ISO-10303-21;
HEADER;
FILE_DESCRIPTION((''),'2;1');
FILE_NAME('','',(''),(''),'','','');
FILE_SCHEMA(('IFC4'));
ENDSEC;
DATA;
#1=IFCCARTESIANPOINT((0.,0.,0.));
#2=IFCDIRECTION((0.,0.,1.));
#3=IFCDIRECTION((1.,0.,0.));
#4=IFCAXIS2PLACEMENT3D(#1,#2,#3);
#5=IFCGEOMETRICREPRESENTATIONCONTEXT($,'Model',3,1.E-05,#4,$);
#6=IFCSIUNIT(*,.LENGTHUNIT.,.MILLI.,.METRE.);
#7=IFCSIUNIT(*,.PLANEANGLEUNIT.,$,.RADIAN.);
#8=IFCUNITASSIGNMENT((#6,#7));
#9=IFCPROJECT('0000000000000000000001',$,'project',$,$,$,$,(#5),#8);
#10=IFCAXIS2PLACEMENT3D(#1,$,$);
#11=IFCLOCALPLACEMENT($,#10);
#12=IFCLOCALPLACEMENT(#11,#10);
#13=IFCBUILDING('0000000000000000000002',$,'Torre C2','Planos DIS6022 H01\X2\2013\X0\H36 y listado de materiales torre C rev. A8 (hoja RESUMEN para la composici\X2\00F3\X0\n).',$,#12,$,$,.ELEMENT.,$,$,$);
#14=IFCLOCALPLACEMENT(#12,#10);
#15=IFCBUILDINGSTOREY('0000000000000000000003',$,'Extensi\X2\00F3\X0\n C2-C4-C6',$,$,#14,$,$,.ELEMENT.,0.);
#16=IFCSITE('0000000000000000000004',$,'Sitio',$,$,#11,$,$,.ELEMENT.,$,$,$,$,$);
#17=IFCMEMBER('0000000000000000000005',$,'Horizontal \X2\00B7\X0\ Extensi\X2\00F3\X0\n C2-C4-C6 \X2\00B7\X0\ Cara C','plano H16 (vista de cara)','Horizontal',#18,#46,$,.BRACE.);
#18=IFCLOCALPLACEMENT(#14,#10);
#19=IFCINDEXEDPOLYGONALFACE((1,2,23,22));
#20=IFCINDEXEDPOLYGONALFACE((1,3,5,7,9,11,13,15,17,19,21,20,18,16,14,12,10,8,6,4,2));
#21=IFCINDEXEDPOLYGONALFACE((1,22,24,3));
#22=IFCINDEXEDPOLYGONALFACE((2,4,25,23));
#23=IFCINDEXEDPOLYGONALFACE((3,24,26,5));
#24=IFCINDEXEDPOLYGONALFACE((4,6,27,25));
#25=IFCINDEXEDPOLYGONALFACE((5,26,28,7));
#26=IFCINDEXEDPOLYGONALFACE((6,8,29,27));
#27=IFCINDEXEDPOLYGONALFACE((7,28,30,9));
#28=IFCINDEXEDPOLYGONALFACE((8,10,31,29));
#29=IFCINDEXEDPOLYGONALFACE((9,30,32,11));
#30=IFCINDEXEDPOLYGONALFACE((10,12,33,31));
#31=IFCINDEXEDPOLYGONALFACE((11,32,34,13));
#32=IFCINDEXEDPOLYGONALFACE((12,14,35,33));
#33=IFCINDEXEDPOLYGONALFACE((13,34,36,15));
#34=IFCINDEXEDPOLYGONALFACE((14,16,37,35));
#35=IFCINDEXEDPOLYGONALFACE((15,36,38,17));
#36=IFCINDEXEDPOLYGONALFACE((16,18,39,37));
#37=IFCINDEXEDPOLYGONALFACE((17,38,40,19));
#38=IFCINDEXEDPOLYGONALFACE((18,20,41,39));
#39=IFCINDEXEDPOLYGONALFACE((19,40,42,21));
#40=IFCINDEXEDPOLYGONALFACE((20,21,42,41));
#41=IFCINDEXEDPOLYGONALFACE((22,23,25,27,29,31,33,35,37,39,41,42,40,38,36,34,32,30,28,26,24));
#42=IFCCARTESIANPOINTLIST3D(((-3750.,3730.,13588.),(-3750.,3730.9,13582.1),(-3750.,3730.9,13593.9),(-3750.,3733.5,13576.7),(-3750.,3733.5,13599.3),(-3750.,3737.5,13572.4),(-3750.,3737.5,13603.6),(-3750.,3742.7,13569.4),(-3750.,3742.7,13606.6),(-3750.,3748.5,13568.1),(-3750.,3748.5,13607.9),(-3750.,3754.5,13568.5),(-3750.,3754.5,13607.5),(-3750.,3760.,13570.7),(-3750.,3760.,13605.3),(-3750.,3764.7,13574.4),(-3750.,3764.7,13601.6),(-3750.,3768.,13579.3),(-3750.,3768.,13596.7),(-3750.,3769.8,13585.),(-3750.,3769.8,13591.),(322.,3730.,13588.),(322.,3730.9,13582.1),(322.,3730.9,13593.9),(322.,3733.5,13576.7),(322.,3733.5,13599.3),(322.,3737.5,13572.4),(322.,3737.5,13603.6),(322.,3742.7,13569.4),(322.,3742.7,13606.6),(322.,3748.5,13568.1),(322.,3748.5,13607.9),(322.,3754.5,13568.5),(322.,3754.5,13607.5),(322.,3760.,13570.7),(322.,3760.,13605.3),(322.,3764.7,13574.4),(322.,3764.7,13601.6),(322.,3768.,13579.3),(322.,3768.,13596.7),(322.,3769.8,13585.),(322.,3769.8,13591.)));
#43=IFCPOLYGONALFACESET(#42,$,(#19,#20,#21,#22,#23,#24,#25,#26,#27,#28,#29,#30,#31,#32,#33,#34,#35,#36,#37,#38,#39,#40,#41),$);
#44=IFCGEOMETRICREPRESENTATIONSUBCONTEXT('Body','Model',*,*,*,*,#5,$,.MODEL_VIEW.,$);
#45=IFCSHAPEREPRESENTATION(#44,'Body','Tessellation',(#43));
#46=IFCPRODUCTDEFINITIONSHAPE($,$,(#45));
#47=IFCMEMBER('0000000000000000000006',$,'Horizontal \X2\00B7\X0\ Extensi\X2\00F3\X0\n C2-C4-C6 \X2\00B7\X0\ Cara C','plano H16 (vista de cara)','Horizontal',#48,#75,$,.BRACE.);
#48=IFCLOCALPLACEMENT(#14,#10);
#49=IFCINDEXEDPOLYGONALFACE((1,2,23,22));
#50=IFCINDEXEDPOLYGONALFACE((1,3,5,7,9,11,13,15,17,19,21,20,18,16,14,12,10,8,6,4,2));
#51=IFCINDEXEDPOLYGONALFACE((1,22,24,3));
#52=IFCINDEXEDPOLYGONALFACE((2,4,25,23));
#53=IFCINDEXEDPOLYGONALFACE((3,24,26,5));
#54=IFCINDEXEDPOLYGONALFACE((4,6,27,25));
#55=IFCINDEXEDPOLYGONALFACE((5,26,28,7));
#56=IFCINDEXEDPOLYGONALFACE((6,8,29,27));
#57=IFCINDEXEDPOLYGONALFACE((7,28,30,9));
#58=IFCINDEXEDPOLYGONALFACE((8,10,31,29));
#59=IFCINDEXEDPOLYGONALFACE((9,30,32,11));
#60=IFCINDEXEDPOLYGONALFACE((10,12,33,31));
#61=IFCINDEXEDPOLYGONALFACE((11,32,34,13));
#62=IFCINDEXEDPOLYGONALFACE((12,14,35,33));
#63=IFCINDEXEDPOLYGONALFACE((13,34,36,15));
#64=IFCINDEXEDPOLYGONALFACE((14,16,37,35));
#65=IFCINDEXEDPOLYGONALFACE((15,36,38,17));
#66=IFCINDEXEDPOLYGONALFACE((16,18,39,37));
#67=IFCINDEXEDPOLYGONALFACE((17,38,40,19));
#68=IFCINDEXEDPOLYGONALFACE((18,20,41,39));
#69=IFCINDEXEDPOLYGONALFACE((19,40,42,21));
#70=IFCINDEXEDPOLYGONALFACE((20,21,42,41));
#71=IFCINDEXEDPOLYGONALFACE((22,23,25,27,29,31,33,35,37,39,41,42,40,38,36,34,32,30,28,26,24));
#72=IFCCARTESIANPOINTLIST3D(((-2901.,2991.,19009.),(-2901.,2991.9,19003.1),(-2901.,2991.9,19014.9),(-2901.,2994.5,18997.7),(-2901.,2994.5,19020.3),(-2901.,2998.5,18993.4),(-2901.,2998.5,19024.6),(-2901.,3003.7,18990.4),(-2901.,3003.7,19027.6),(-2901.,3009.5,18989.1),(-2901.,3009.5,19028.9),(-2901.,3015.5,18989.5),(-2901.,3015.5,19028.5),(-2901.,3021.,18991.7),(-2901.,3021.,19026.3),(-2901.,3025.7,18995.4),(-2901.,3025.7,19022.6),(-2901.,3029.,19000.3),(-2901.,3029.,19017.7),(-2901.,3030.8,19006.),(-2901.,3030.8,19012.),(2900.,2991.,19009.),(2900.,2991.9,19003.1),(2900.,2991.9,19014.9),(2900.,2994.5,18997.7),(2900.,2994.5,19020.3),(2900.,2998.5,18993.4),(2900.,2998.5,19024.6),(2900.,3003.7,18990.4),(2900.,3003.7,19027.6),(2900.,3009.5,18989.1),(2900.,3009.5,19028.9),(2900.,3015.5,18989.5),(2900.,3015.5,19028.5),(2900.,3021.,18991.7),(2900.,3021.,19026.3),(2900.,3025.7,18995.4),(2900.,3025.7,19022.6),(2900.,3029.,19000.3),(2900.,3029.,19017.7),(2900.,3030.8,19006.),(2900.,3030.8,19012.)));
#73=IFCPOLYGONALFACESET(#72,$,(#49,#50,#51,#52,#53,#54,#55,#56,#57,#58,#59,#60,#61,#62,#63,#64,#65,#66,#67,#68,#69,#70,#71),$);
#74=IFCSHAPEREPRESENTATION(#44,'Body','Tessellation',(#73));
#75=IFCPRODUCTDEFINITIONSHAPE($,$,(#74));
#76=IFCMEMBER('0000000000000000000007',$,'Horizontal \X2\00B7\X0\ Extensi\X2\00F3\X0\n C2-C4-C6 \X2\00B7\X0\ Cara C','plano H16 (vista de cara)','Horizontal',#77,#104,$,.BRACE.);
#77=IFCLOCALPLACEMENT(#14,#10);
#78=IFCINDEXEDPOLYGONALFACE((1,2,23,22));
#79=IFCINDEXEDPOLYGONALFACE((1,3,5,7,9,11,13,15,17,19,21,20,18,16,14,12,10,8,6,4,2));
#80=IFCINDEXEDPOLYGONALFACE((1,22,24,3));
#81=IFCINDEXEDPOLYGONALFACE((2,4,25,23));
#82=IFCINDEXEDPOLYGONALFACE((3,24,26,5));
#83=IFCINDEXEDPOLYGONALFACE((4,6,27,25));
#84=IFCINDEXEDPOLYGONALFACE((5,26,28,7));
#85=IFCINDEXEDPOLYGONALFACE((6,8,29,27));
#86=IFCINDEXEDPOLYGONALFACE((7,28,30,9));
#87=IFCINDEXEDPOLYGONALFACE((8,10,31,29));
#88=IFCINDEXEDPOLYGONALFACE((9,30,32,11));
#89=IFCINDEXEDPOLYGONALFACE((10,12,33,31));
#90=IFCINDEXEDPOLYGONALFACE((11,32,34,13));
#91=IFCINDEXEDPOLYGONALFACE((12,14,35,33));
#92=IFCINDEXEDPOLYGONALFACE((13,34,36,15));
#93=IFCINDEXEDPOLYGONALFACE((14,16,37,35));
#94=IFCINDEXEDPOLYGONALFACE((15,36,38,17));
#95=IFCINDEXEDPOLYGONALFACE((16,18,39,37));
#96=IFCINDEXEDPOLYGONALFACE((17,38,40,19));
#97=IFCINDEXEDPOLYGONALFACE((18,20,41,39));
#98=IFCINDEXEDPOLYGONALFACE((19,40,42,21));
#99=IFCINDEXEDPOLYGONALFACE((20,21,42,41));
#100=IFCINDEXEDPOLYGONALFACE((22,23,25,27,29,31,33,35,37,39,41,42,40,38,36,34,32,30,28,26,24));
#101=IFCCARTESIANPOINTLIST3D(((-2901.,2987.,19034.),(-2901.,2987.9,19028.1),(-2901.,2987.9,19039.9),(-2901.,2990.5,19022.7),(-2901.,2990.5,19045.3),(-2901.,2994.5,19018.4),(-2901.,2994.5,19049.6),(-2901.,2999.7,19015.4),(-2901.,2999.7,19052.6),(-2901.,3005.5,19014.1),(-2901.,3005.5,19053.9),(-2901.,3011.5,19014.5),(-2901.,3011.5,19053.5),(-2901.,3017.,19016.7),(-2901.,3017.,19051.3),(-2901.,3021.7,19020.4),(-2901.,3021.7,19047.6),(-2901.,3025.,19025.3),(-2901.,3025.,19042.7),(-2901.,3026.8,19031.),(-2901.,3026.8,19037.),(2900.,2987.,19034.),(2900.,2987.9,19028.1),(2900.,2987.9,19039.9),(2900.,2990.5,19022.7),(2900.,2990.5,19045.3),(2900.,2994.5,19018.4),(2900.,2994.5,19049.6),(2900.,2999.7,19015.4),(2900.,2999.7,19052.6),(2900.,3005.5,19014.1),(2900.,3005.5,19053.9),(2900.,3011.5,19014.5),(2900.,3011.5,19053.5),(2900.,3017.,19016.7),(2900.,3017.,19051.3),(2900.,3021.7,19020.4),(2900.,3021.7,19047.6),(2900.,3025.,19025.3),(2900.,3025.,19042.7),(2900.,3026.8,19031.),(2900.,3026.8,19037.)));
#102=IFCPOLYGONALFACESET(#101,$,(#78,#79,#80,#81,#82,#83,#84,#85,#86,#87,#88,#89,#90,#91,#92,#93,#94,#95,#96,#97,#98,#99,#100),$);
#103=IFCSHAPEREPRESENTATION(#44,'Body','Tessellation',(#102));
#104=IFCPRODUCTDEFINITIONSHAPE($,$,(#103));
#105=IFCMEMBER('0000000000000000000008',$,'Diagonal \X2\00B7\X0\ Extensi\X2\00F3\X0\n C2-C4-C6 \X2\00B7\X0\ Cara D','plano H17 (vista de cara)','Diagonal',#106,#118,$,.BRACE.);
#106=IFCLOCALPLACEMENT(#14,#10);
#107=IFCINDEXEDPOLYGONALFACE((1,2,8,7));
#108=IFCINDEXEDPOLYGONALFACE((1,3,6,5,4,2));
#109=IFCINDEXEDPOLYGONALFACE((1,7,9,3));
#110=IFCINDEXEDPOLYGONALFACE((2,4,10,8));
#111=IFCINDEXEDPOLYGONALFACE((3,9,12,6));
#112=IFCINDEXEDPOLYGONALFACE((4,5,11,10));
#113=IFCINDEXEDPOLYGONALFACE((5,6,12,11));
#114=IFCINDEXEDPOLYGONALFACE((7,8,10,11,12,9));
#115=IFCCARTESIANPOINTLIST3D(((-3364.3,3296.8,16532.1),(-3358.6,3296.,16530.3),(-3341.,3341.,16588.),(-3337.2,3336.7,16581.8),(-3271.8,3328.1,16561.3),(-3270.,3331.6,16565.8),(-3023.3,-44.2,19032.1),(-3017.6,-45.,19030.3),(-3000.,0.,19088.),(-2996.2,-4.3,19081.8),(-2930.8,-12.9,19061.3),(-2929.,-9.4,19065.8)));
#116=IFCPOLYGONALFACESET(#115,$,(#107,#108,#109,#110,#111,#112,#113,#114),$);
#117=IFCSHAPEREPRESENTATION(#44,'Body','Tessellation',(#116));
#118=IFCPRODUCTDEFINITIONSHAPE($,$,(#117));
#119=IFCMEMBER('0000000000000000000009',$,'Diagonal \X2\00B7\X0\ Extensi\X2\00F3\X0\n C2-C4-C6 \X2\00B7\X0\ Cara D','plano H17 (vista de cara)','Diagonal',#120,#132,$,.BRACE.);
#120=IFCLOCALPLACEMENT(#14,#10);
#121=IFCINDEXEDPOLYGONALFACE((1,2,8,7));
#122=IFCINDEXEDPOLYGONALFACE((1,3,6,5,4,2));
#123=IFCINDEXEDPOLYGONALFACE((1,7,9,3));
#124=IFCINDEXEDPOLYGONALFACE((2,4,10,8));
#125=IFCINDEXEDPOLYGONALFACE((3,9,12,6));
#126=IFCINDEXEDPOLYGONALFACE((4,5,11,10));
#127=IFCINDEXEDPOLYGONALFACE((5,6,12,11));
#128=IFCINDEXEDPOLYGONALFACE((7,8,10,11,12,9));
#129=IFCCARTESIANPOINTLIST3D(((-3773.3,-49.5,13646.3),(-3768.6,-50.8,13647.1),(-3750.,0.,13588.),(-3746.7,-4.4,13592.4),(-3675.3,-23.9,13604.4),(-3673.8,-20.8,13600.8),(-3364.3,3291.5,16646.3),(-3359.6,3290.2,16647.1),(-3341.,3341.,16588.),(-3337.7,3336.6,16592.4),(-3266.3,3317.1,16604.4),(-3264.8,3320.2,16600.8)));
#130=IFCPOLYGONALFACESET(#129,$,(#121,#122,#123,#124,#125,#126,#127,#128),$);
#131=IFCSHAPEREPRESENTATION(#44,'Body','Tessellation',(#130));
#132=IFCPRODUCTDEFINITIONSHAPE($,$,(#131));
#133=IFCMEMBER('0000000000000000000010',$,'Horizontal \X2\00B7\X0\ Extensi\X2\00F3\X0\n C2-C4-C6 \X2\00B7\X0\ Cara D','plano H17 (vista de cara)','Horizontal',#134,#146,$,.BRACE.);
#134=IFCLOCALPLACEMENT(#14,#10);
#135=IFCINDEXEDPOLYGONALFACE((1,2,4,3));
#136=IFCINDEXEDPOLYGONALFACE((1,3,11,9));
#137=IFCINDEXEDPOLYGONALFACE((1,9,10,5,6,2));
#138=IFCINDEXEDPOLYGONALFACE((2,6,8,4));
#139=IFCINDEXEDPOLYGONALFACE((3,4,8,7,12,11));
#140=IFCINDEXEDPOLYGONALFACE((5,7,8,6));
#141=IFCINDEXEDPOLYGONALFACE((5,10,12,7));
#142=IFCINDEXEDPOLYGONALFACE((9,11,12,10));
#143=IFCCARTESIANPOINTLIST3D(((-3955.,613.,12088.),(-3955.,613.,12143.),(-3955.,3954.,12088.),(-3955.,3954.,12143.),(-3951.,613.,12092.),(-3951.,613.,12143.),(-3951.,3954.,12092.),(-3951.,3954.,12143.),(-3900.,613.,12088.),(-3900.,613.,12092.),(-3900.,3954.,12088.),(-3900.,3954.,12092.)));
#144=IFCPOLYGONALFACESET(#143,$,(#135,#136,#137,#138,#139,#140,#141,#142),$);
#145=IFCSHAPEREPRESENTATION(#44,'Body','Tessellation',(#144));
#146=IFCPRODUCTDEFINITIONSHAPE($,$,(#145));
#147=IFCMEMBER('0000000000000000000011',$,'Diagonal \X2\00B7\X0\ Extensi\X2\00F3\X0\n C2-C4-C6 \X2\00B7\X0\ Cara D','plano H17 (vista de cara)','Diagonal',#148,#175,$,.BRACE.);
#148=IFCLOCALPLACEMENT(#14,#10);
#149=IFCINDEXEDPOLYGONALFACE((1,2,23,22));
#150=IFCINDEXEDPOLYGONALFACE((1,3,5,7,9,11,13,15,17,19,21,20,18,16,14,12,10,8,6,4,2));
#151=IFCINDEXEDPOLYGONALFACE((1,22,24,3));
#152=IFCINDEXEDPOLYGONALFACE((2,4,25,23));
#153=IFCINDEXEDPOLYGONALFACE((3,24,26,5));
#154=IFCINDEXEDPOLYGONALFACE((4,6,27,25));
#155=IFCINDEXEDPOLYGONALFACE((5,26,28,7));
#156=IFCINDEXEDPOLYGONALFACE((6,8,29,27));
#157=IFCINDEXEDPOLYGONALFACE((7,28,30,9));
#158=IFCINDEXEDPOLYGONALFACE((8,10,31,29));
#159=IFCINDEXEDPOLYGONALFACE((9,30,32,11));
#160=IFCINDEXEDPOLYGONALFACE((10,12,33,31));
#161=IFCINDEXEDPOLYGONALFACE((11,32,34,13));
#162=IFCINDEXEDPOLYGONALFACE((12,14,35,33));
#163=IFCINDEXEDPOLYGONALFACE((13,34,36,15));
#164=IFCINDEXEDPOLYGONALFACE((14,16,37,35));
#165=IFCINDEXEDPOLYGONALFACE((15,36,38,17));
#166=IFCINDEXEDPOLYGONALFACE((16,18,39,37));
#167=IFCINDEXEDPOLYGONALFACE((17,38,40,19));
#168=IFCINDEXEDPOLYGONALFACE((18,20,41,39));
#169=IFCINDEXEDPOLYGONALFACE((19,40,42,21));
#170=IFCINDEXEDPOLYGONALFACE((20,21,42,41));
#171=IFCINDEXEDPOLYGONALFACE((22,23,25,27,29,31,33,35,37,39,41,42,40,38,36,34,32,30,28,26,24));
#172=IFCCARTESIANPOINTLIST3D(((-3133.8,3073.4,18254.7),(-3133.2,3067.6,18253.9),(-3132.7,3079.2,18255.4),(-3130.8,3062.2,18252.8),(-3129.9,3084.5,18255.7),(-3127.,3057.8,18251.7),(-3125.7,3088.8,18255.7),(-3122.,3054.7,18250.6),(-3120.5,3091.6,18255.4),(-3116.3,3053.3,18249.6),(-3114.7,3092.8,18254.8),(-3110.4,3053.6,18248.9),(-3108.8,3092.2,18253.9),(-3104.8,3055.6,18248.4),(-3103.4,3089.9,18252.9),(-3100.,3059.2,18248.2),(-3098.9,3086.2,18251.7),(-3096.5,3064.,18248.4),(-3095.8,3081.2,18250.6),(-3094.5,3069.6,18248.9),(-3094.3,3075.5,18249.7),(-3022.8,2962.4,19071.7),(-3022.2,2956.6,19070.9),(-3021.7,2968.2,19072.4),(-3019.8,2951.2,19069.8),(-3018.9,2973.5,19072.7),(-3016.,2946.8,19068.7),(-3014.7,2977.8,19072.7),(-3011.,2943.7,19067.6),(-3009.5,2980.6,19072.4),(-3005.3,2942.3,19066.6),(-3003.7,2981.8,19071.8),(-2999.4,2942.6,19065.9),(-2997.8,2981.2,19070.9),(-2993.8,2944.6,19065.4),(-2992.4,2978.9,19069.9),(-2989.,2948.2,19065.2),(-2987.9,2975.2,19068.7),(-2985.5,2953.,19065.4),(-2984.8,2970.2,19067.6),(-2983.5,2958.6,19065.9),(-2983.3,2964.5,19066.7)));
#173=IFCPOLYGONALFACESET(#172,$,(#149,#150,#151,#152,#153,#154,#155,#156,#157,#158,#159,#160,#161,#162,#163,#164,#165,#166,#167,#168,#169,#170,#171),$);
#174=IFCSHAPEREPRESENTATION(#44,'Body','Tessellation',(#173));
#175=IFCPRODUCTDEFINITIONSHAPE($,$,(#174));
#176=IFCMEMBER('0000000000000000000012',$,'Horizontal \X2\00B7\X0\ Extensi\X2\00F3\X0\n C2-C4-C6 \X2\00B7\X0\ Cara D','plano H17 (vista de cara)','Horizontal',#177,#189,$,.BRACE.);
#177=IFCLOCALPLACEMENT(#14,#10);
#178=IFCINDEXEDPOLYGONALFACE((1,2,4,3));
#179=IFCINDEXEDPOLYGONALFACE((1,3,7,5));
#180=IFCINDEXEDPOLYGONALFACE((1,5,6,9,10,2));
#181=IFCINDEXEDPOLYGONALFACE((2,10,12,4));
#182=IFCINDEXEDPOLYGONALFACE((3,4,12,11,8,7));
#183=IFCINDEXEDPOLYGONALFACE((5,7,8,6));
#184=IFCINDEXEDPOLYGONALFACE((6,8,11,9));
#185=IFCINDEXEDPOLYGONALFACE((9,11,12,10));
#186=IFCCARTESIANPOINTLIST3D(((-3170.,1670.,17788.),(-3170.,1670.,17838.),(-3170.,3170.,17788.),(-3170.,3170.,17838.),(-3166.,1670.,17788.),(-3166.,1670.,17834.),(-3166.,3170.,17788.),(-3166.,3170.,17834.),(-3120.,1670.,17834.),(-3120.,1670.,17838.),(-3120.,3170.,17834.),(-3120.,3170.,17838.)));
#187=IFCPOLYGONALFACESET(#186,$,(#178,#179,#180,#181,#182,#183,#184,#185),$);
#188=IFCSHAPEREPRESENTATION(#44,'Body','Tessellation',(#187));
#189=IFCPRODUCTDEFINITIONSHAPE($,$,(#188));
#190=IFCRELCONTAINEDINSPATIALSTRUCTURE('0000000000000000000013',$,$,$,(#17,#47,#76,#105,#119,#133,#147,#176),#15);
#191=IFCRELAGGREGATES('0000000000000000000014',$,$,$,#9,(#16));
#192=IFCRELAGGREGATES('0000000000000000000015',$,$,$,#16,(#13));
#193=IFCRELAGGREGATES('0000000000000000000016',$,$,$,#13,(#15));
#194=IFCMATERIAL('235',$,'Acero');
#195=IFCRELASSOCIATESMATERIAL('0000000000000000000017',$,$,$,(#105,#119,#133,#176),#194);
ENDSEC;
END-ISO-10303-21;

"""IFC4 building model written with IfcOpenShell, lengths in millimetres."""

from ifc_helpers import new_model, si_unit, frame, frame_2d, origin, origin_with_axes, place, context, subcontext, project, spatial, circle, l_section, extrude, material, element, save


model = new_model("IFC4")

# Units and contexts
model_context = context("Model", 3, precision=1e-05, world=origin_with_axes())
body_context = subcontext(model_context, "Body", "Model", "MODEL_VIEW")
ifc_project = project(units=[si_unit("LENGTHUNIT", "METRE", prefix="MILLI"), si_unit("PLANEANGLEUNIT", "RADIAN")], contexts=[model_context])

# Site, building, storey
site_placement = place(None, origin())
site = spatial("IfcSite", under=ifc_project, at=site_placement, Name="Sitio", CompositionType="ELEMENT")
building_placement = place(site_placement, origin())
building = spatial("IfcBuilding", under=site, at=building_placement, Name="Torre C2", Description="Planos DIS6022 H01–H36 y listado de materiales torre C rev. A8 (hoja RESUMEN para la composición).", CompositionType="ELEMENT")
storey_placement = place(building_placement, origin())
storey = spatial("IfcBuildingStorey", under=building, at=storey_placement, Name="Extensión C2-C4-C6", CompositionType="ELEMENT", Elevation=0.0)

# Members
ifc_material_1 = material(Name="235", Category="Acero")
member_1_placement = place(storey_placement, frame((-3750.0, 3750.0, 13588.0), z_axis=(1.0, 0.0, 0.0), x_axis=(0.0, -1.0, 0.0)))
element("IfcMember", 1, at=member_1_placement, inside=storey, Name="Horizontal · Extensión C2-C4-C6 · Cara C", Description="plano H16 (vista de cara)", ObjectType="Horizontal", PredefinedType="BRACE", context=body_context, shape_type="SweptSolid", body=[
    extrude(circle(Radius=20.0), None, (0.0, 0.0, 1.0), 4072.0),
])
for number, where, z_axis, x_axis, name in (
    (2, (-2901.0, 3011.0, 19009.0), (1.0, 0.0, 0.0), (0.0, -1.0, 0.0), "Horizontal · Extensión C2-C4-C6 · Cara C"),
    (3, (-2901.0, 3007.0, 19034.0), (1.0, 0.0, 0.0), (0.0, -1.0, 0.0), "Horizontal · Extensión C2-C4-C6 · Cara C"),
):
    element("IfcMember", number, at=place(storey_placement, frame(where, z_axis=z_axis, x_axis=x_axis)), inside=storey, Name=name, Description="plano H16 (vista de cara)", ObjectType="Horizontal", PredefinedType="BRACE", context=body_context, shape_type="SweptSolid", body=[
        extrude(circle(Radius=20.0), None, (0.0, 0.0, 1.0), 5801.0),
    ])
member_2_placement = place(storey_placement, frame((-3000.0, 0.0, 19088.0), z_axis=(-0.081448, 0.798001, -0.597127), x_axis=(0.947028, -0.124774, -0.295923)))
element("IfcMember", 4, at=member_2_placement, inside=storey, material=ifc_material_1, Name="Diagonal · Extensión C2-C4-C6 · Cara D", Description="plano H17 (vista de cara)", ObjectType="Diagonal", PredefinedType="BRACE", context=body_context, shape_type="SweptSolid", body=[
    extrude(l_section(Depth=75.0, Width=75.0, Thickness=6.0, at=frame_2d((37.5, 37.5))), None, (0.0, 0.0, 1.0), 4186.7),
])
member_3_placement = place(storey_placement, frame((-3341.0, 3341.0, 16588.0), z_axis=(-0.090711, -0.74099, -0.665361), x_axis=(0.952207, -0.260212, 0.159972)))
element("IfcMember", 5, at=member_3_placement, inside=storey, material=ifc_material_1, Name="Diagonal · Extensión C2-C4-C6 · Cara D", Description="plano H17 (vista de cara)", ObjectType="Diagonal", PredefinedType="BRACE", context=body_context, shape_type="SweptSolid", body=[
    extrude(l_section(Depth=80.0, Width=80.0, Thickness=5.0, at=frame_2d((40.0, 40.0))), None, (0.0, 0.0, 1.0), 4508.8),
])
member_4_placement = place(storey_placement, frame((-3955.0, 3954.0, 12088.0), z_axis=(0.0, -1.0, 0.0), x_axis=(1.0, 0.0, 0.0)))
element("IfcMember", 6, at=member_4_placement, inside=storey, material=ifc_material_1, Name="Horizontal · Extensión C2-C4-C6 · Cara D", Description="plano H17 (vista de cara)", ObjectType="Horizontal", PredefinedType="BRACE", context=body_context, shape_type="SweptSolid", body=[
    extrude(l_section(Depth=55.0, Width=55.0, Thickness=4.0, at=frame_2d((27.5, 27.5))), None, (0.0, 0.0, 1.0), 3341.0),
])
member_5_placement = place(storey_placement, frame((-3003.0, 2962.0, 19069.0), z_axis=(-0.133422, 0.133422, -0.982037), x_axis=(0.699247, -0.68953, -0.188683)))
element("IfcMember", 7, at=member_5_placement, inside=storey, Name="Diagonal · Extensión C2-C4-C6 · Cara D", Description="plano H17 (vista de cara)", ObjectType="Diagonal", PredefinedType="BRACE", context=body_context, shape_type="SweptSolid", body=[
    extrude(circle(Radius=20.0), None, (0.0, 0.0, 1.0), 831.9),
])
member_6_placement = place(storey_placement, frame((-3170.0, 1670.0, 17838.0), z_axis=(0.0, 1.0, 0.0), x_axis=(1.0, 0.0, 0.0)))
element("IfcMember", 8, at=member_6_placement, inside=storey, material=ifc_material_1, Name="Horizontal · Extensión C2-C4-C6 · Cara D", Description="plano H17 (vista de cara)", ObjectType="Horizontal", PredefinedType="BRACE", context=body_context, shape_type="SweptSolid", body=[
    extrude(l_section(Depth=50.0, Width=50.0, Thickness=4.0, at=frame_2d((25.0, 25.0))), None, (0.0, 0.0, 1.0), 1500.0),
])

save(model, "model.ifc")
